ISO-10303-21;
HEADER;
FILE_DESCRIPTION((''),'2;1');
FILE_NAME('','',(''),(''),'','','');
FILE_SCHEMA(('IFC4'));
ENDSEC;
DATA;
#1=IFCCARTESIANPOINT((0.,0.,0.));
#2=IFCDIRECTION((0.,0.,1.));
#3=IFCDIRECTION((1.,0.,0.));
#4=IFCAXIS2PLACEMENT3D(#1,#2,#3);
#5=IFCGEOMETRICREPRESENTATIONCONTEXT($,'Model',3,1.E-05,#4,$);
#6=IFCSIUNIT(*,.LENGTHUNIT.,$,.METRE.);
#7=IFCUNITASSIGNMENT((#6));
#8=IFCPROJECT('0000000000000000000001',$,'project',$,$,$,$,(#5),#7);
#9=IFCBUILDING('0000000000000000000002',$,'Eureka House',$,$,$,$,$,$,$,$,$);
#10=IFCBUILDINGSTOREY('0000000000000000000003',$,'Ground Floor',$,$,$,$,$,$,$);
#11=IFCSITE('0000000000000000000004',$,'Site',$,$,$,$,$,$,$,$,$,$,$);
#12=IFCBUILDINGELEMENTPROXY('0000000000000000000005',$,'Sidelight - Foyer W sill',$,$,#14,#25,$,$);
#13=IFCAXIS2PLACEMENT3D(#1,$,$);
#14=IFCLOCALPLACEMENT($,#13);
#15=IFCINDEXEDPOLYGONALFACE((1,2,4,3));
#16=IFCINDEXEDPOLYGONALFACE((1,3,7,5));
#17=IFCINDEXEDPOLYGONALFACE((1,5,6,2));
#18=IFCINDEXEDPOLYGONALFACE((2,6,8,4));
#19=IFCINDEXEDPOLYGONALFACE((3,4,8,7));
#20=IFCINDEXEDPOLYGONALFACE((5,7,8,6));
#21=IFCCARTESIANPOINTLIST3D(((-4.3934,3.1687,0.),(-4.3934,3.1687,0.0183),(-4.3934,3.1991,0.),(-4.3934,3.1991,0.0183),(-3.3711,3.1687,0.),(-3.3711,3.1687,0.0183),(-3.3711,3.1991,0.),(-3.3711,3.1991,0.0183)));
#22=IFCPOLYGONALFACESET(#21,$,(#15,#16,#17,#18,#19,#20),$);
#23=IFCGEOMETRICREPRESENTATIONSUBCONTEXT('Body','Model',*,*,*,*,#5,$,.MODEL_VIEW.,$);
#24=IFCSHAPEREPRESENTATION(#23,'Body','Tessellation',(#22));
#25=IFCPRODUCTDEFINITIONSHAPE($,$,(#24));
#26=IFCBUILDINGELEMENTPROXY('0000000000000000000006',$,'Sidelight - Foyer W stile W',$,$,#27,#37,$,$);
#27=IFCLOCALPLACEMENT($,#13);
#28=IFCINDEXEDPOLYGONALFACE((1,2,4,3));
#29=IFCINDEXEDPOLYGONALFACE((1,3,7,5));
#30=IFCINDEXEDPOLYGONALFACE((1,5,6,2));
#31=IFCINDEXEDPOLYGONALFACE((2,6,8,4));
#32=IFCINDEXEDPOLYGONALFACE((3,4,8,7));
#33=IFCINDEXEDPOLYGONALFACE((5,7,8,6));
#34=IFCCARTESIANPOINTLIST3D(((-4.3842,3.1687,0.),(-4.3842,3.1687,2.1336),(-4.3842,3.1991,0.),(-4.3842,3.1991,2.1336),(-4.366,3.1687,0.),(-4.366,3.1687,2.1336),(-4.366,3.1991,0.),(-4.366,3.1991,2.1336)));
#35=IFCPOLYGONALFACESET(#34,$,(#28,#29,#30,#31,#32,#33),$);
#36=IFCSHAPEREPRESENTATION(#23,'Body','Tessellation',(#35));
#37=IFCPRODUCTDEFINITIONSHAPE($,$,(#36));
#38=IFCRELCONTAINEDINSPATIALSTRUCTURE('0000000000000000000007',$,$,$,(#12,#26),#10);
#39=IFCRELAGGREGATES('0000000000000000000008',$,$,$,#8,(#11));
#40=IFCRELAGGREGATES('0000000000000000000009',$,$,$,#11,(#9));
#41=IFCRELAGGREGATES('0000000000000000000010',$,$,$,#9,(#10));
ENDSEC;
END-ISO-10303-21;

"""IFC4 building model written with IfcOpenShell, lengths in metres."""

from ifc_helpers import new_model, si_unit, frame, origin, origin_with_axes, origin_2d, place, context, subcontext, project, spatial, rectangle, extrude, element, save


model = new_model("IFC4")

# Units and contexts
model_context = context("Model", 3, precision=1e-05, world=origin_with_axes())
body_context = subcontext(model_context, "Body", "Model", "MODEL_VIEW")
ifc_project = project(units=[si_unit("LENGTHUNIT", "METRE")], contexts=[model_context])

# Site, building, storey
site = spatial("IfcSite", under=ifc_project, Name="Site")
building = spatial("IfcBuilding", under=site, Name="Eureka House")
storey = spatial("IfcBuildingStorey", under=building, Name="Ground Floor")

# Building element proxies
proxy_1_placement = place(None, frame((-3.8822, 3.1839, 0.0), z_axis=(0.0, 0.0, 1.0), x_axis=(1.0, 0.0, 0.0)))
element("IfcBuildingElementProxy", 1, at=proxy_1_placement, inside=storey, Name="Sidelight - Foyer W sill", context=body_context, shape_type="SweptSolid", body=[
    extrude(rectangle(XDim=1.0223, YDim=0.0305, at=origin_2d()), origin(), (0.0, 0.0, 1.0), 0.0183),
])
proxy_2_placement = place(None, frame((-4.3751, 3.1839, 0.0), z_axis=(0.0, 0.0, 1.0), x_axis=(1.0, 0.0, 0.0)))
element("IfcBuildingElementProxy", 2, at=proxy_2_placement, inside=storey, Name="Sidelight - Foyer W stile W", context=body_context, shape_type="SweptSolid", body=[
    extrude(rectangle(XDim=0.0183, YDim=0.0305, at=origin_2d()), origin(), (0.0, 0.0, 1.0), 2.1336),
])

save(model, "model.ifc")
